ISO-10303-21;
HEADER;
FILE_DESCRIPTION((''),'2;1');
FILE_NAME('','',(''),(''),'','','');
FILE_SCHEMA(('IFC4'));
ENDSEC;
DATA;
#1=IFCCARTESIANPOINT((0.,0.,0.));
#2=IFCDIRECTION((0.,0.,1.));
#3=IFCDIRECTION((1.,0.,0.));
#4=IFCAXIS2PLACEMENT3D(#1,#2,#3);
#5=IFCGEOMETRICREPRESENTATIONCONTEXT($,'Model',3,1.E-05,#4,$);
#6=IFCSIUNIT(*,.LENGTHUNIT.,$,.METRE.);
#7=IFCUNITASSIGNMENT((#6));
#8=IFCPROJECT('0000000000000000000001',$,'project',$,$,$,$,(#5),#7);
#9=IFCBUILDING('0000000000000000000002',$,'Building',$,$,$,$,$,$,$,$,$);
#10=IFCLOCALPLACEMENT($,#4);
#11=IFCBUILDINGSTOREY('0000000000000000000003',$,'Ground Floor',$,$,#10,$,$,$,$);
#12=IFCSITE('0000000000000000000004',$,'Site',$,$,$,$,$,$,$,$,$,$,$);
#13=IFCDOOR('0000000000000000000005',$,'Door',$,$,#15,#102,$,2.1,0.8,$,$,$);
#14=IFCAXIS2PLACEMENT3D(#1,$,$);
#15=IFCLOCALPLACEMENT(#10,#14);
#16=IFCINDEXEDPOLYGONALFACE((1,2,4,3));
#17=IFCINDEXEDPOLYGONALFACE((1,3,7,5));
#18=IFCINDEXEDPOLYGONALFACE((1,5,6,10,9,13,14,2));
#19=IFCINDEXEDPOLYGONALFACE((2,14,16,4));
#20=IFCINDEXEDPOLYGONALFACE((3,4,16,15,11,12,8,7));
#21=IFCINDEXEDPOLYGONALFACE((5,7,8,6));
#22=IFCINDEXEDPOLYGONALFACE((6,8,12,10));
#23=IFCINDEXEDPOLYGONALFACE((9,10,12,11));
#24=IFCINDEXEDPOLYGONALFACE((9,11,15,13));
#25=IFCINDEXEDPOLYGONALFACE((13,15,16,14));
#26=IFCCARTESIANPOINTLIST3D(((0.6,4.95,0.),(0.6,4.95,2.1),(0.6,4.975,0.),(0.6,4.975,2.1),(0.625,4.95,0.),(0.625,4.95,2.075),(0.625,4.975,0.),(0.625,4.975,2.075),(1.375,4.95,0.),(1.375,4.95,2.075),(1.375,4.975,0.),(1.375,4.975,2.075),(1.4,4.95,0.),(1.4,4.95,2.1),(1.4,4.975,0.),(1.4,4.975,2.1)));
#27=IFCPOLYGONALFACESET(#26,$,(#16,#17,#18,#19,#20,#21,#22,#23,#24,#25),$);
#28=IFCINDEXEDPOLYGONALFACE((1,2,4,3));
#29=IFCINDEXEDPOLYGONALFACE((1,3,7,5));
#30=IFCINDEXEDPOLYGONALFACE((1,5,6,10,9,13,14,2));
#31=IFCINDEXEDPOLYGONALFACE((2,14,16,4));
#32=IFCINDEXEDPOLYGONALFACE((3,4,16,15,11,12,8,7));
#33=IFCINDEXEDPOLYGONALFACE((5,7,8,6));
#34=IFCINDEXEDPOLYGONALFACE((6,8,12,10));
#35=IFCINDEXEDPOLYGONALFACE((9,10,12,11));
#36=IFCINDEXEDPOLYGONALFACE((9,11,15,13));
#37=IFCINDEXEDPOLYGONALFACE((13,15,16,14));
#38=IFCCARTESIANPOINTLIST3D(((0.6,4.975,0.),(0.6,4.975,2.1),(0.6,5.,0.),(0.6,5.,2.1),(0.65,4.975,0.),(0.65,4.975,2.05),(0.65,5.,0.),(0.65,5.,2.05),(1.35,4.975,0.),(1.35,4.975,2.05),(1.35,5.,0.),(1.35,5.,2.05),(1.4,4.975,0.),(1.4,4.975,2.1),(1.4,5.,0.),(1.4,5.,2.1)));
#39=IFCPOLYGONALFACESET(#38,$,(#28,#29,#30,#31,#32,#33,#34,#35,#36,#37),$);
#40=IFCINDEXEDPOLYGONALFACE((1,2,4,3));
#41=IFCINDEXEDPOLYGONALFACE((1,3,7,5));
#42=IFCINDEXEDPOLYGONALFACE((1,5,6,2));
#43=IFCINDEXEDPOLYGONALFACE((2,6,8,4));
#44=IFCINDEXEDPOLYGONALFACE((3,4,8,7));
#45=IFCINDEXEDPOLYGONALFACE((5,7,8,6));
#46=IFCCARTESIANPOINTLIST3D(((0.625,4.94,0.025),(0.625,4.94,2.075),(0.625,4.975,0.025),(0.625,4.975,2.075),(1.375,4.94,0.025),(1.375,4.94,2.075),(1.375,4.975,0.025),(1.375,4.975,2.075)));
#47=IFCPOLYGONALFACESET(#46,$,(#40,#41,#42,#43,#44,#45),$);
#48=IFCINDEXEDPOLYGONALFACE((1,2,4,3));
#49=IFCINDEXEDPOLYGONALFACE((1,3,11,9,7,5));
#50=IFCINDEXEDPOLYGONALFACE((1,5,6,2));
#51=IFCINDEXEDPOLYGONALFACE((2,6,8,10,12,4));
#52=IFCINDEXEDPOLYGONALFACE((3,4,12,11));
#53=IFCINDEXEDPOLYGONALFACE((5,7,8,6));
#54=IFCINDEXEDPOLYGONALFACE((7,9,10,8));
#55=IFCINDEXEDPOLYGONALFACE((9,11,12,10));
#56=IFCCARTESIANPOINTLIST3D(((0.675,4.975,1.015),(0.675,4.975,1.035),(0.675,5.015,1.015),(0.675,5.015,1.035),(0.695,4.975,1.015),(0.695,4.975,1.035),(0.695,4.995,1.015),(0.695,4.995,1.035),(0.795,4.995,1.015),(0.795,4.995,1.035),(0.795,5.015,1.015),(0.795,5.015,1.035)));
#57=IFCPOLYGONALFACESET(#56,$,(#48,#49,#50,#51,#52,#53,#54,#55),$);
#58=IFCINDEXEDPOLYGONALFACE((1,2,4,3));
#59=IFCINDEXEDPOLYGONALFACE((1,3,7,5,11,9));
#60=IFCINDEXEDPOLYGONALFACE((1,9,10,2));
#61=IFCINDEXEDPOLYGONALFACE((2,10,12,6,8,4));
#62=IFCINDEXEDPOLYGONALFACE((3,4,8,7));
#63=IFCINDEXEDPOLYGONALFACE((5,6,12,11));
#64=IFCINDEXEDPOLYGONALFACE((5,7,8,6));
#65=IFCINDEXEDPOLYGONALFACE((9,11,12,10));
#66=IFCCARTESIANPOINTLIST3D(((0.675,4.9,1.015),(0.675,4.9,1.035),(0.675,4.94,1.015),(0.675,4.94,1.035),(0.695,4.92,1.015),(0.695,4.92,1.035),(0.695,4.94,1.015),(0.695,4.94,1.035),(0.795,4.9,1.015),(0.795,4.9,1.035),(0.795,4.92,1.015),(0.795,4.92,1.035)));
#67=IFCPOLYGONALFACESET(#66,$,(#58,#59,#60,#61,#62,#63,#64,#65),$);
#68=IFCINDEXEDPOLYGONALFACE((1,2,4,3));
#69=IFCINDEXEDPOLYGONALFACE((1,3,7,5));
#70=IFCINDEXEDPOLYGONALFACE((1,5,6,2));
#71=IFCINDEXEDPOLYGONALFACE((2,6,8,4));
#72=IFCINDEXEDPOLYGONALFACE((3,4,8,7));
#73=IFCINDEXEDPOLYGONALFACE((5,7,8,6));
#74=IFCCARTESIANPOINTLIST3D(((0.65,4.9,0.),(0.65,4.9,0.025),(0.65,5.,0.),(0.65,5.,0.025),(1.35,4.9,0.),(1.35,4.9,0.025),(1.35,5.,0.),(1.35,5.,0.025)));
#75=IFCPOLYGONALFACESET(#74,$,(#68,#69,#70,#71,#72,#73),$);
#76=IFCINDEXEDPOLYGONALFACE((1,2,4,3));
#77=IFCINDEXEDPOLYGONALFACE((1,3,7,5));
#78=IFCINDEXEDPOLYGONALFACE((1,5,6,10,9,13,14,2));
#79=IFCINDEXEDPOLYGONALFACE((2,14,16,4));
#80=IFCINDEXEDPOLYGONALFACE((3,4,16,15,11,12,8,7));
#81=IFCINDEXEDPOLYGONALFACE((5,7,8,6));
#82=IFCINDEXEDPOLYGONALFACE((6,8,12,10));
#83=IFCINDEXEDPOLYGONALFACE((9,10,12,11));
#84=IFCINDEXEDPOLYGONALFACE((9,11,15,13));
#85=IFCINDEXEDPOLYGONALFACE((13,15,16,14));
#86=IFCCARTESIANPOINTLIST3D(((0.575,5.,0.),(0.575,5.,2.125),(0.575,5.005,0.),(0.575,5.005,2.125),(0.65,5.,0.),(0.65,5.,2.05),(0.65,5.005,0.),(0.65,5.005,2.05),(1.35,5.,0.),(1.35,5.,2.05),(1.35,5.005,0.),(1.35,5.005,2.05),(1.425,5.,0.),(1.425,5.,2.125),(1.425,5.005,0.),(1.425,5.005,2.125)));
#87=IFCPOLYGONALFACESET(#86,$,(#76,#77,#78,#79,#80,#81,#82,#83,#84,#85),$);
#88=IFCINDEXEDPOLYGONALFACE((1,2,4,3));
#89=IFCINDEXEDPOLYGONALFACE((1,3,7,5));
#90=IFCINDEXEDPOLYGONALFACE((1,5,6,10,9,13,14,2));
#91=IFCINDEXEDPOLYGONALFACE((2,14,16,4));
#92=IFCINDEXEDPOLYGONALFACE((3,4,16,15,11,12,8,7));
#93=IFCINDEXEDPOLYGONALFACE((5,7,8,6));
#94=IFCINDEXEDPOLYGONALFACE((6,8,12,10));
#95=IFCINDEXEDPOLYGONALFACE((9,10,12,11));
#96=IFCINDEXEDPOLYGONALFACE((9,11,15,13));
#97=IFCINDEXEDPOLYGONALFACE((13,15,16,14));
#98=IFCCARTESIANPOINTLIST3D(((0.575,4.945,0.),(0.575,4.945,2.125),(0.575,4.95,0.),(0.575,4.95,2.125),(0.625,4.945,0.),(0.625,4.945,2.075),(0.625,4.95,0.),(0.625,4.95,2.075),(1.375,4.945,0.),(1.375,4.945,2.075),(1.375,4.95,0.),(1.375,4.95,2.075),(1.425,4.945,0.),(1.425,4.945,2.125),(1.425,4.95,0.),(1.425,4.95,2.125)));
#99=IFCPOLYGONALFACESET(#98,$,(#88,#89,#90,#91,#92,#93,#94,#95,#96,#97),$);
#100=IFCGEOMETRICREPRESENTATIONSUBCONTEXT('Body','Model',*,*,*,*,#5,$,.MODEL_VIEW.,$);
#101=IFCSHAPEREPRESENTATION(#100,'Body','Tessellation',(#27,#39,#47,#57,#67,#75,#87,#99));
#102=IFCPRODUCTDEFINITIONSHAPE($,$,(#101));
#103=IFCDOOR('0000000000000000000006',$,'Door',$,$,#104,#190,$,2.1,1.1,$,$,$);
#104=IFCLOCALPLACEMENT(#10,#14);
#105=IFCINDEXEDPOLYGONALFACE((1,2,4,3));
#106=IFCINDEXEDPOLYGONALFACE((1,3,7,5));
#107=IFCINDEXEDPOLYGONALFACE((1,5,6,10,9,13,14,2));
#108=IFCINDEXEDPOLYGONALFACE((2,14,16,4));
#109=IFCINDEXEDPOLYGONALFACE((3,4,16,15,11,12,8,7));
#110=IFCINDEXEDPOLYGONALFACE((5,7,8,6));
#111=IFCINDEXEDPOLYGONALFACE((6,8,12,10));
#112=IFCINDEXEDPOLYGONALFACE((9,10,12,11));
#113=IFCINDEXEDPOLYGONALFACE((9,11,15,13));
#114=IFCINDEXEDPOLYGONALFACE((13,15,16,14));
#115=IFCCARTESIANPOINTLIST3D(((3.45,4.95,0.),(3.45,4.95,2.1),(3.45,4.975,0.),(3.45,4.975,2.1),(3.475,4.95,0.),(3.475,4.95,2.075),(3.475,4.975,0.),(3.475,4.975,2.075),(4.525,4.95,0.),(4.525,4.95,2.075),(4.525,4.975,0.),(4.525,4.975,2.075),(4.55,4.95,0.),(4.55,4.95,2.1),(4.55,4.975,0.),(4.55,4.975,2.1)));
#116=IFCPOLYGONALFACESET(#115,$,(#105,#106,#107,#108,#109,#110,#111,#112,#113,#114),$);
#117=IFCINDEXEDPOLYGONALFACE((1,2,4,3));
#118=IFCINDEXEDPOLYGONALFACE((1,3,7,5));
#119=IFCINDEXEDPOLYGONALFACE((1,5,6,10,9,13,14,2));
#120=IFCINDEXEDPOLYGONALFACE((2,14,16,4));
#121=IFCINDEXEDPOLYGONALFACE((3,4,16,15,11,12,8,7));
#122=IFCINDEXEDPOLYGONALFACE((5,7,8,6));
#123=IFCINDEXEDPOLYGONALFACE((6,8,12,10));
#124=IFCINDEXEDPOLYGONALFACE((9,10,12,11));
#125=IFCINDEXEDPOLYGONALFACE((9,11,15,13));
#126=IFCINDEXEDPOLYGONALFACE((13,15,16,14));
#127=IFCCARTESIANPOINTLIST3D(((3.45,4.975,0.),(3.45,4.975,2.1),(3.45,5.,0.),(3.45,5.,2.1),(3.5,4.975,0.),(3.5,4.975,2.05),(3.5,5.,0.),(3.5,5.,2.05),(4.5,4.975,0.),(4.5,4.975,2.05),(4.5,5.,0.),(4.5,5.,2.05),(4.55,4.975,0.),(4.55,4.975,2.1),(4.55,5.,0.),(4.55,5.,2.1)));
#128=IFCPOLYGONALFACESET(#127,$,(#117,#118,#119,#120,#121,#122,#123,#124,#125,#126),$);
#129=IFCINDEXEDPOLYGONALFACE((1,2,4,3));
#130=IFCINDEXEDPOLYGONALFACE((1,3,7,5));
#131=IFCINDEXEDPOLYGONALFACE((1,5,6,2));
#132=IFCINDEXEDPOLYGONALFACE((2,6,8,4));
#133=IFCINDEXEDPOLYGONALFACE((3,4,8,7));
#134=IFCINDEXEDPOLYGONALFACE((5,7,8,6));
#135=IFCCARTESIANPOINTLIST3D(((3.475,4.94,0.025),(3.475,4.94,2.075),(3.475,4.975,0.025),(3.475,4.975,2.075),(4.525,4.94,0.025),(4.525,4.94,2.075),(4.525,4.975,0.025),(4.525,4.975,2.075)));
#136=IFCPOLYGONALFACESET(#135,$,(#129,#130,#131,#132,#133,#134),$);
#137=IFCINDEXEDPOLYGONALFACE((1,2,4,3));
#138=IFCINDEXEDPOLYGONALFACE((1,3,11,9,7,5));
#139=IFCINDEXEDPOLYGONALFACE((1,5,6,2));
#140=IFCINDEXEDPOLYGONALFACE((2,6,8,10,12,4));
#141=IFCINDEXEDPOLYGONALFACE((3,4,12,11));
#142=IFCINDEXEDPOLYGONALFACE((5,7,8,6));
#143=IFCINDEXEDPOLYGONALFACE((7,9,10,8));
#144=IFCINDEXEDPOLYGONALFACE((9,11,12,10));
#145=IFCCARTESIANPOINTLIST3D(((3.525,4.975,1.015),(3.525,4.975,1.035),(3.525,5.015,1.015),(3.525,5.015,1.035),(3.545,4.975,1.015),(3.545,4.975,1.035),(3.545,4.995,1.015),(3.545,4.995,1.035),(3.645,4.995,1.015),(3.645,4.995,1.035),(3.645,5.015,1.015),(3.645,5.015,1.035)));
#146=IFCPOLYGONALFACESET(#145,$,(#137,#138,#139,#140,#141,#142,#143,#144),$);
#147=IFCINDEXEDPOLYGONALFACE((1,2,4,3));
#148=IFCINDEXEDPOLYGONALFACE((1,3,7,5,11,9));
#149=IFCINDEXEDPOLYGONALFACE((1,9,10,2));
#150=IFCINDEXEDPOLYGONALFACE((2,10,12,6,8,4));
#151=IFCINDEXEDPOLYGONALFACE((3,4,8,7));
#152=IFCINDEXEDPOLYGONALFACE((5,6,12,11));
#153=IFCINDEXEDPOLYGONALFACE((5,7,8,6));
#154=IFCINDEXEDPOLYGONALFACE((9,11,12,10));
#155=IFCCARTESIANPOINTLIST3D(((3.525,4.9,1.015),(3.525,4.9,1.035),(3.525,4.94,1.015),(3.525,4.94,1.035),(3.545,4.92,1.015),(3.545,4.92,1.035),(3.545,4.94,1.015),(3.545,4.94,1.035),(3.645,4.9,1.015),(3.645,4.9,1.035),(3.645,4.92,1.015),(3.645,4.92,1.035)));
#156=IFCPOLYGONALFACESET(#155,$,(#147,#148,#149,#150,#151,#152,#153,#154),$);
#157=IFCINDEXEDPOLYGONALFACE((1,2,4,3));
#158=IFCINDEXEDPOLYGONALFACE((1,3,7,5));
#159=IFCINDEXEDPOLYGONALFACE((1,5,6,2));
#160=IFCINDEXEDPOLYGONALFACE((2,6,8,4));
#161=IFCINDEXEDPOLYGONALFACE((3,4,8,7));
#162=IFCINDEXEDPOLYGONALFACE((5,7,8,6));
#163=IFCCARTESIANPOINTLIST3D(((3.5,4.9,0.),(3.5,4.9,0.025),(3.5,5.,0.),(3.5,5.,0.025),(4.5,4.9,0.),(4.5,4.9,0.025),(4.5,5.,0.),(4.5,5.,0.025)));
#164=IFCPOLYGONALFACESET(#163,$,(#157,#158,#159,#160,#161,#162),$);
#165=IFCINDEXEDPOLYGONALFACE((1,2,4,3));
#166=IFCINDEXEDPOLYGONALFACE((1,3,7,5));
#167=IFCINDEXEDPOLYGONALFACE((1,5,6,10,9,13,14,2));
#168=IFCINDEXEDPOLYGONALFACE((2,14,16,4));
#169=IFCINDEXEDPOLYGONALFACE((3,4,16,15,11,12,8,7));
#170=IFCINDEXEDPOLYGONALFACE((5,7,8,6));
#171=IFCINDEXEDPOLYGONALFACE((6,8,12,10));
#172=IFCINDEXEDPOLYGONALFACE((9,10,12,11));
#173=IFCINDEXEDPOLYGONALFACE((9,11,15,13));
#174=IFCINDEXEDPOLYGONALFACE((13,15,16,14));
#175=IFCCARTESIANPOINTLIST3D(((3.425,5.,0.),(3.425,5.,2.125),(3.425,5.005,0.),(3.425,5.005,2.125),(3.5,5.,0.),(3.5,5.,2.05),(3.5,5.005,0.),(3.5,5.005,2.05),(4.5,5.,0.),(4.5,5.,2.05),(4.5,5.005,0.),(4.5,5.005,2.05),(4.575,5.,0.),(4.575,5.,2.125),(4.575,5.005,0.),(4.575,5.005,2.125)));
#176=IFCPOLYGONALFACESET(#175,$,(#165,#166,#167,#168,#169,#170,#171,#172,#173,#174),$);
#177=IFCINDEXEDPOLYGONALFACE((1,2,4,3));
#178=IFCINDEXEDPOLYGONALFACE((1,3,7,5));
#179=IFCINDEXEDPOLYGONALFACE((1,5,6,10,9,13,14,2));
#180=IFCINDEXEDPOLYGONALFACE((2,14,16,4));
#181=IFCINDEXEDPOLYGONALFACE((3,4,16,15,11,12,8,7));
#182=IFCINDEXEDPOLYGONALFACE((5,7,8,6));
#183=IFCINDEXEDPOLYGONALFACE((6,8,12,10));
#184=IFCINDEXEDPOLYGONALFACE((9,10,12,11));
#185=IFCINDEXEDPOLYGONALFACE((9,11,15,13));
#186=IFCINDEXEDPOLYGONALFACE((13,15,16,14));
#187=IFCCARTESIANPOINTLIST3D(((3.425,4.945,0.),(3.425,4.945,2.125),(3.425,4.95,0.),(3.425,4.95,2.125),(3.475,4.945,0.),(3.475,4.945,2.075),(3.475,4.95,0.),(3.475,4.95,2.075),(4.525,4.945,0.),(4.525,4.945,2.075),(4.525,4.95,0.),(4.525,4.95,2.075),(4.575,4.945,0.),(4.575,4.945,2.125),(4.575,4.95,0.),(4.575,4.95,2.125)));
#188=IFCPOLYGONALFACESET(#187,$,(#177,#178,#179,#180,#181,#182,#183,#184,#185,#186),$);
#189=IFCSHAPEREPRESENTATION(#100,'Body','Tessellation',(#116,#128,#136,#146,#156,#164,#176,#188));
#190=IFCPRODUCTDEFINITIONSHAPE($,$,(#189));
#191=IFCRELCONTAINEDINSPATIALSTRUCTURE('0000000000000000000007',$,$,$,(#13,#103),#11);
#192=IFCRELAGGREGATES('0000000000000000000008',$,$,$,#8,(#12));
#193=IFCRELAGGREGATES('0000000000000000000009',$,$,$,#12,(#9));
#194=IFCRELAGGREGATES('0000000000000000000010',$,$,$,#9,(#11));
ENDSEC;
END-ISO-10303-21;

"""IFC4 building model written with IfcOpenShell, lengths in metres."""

from ifc_helpers import new_model, si_unit, frame, origin_with_axes, place, context, subcontext, project, spatial, line, indexed_curve, outline, extrude, element, save


model = new_model("IFC4")

# Units and contexts
model_context = context("Model", 3, precision=1e-05, world=origin_with_axes())
body_context = subcontext(model_context, "Body", "Model", "MODEL_VIEW")
ifc_project = project(units=[si_unit("LENGTHUNIT", "METRE")], contexts=[model_context])

# Site, building, storey
site = spatial("IfcSite", under=ifc_project, Name="Site")
building = spatial("IfcBuilding", under=site, Name="Building")
storey_placement = place(None, origin_with_axes())
storey = spatial("IfcBuildingStorey", under=building, at=storey_placement, Name="Ground Floor")

# Doors
door_1_placement = place(storey_placement, frame((1.4, 5.0, 0.0), z_axis=(0.0, 0.0, 1.0), x_axis=(-1.0, 0.0, 0.0)))
element("IfcDoor", 1, at=door_1_placement, inside=storey, Name="Door", OverallHeight=2.1, OverallWidth=0.8, context=body_context, shape_type="SweptSolid", body=[
    extrude(outline(indexed_curve([(0.0, 0.0), (0.0, 2.1), (0.8, 2.1), (0.8, 0.0), (0.775, 0.0), (0.775, 2.075), (0.025, 2.075), (0.025, 0.0)], segments=[line(1, 2, 3, 4, 5, 6, 7, 8, 1)])), frame((0.0, 0.025, 0.0), z_axis=(0.0, -1.0, 0.0), x_axis=(1.0, 0.0, 0.0)), (0.0, 0.0, -1.0), 0.025),
    extrude(outline(indexed_curve([(0.0, 0.0), (0.0, 2.1), (0.8, 2.1), (0.8, 0.0), (0.75, 0.0), (0.75, 2.05), (0.05, 2.05), (0.05, 0.0)], segments=[line(1, 2, 3, 4, 5, 6, 7, 8, 1)])), frame((0.0, 0.0, 0.0), z_axis=(0.0, -1.0, 0.0), x_axis=(1.0, 0.0, 0.0)), (0.0, 0.0, -1.0), 0.025),
    extrude(outline(indexed_curve([(0.0, 0.0), (0.75, 0.0), (0.75, 0.035), (0.0, 0.035)], segments=[line(1, 2, 3, 4, 1)])), frame((0.025, 0.025, 0.025), z_axis=(0.0, 0.0, 1.0), x_axis=(1.0, 0.0, 0.0)), (0.0, 0.0, 1.0), 2.05),
    extrude(outline(indexed_curve([(0.0, 0.0), (0.0, -0.04), (-0.12, -0.04), (-0.12, -0.02), (-0.02, -0.02), (-0.02, 0.0)], segments=[line(1, 2, 3, 4, 5, 6, 1)])), frame((0.725, 0.025, 1.015), z_axis=(0.0, 0.0, 1.0), x_axis=(1.0, 0.0, 0.0)), (0.0, 0.0, 1.0), 0.02),
    extrude(outline(indexed_curve([(0.0, 0.0), (0.0, 0.04), (-0.12, 0.04), (-0.12, 0.02), (-0.02, 0.02), (-0.02, 0.0)], segments=[line(1, 2, 3, 4, 5, 6, 1)])), frame((0.725, 0.06, 1.015), z_axis=(0.0, 0.0, 1.0), x_axis=(1.0, 0.0, 0.0)), (0.0, 0.0, 1.0), 0.02),
    extrude(outline(indexed_curve([(0.0, 0.0), (0.7, 0.0), (0.7, 0.1), (0.0, 0.1)], segments=[line(1, 2, 3, 4, 1)])), frame((0.05, 0.0, 0.0), z_axis=(0.0, 0.0, 1.0), x_axis=(1.0, 0.0, 0.0)), (0.0, 0.0, 1.0), 0.025),
    extrude(outline(indexed_curve([(0.0, 0.0), (0.0, 2.125), (0.85, 2.125), (0.85, 0.0), (0.775, 0.0), (0.775, 2.05), (0.075, 2.05), (0.075, 0.0)], segments=[line(1, 2, 3, 4, 5, 6, 7, 8, 1)])), frame((-0.025, -0.005, 0.0), z_axis=(0.0, -1.0, 0.0), x_axis=(1.0, 0.0, 0.0)), (0.0, 0.0, -1.0), 0.005),
    extrude(outline(indexed_curve([(0.0, 0.0), (0.0, 2.125), (0.85, 2.125), (0.85, 0.0), (0.8, 0.0), (0.8, 2.075), (0.05, 2.075), (0.05, 0.0)], segments=[line(1, 2, 3, 4, 5, 6, 7, 8, 1)])), frame((-0.025, 0.05, 0.0), z_axis=(0.0, -1.0, 0.0), x_axis=(1.0, 0.0, 0.0)), (0.0, 0.0, -1.0), 0.005),
])
door_2_placement = place(storey_placement, frame((4.55, 5.0, 0.0), z_axis=(0.0, 0.0, 1.0), x_axis=(-1.0, 0.0, 0.0)))
element("IfcDoor", 2, at=door_2_placement, inside=storey, Name="Door", OverallHeight=2.1, OverallWidth=1.1, context=body_context, shape_type="SweptSolid", body=[
    extrude(outline(indexed_curve([(0.0, 0.0), (0.0, 2.1), (1.1, 2.1), (1.1, 0.0), (1.075, 0.0), (1.075, 2.075), (0.025, 2.075), (0.025, 0.0)], segments=[line(1, 2, 3, 4, 5, 6, 7, 8, 1)])), frame((0.0, 0.025, 0.0), z_axis=(0.0, -1.0, 0.0), x_axis=(1.0, 0.0, 0.0)), (0.0, 0.0, -1.0), 0.025),
    extrude(outline(indexed_curve([(0.0, 0.0), (0.0, 2.1), (1.1, 2.1), (1.1, 0.0), (1.05, 0.0), (1.05, 2.05), (0.05, 2.05), (0.05, 0.0)], segments=[line(1, 2, 3, 4, 5, 6, 7, 8, 1)])), frame((0.0, 0.0, 0.0), z_axis=(0.0, -1.0, 0.0), x_axis=(1.0, 0.0, 0.0)), (0.0, 0.0, -1.0), 0.025),
    extrude(outline(indexed_curve([(0.0, 0.0), (1.05, 0.0), (1.05, 0.035), (0.0, 0.035)], segments=[line(1, 2, 3, 4, 1)])), frame((0.025, 0.025, 0.025), z_axis=(0.0, 0.0, 1.0), x_axis=(1.0, 0.0, 0.0)), (0.0, 0.0, 1.0), 2.05),
    extrude(outline(indexed_curve([(0.0, 0.0), (0.0, -0.04), (-0.12, -0.04), (-0.12, -0.02), (-0.02, -0.02), (-0.02, 0.0)], segments=[line(1, 2, 3, 4, 5, 6, 1)])), frame((1.025, 0.025, 1.015), z_axis=(0.0, 0.0, 1.0), x_axis=(1.0, 0.0, 0.0)), (0.0, 0.0, 1.0), 0.02),
    extrude(outline(indexed_curve([(0.0, 0.0), (0.0, 0.04), (-0.12, 0.04), (-0.12, 0.02), (-0.02, 0.02), (-0.02, 0.0)], segments=[line(1, 2, 3, 4, 5, 6, 1)])), frame((1.025, 0.06, 1.015), z_axis=(0.0, 0.0, 1.0), x_axis=(1.0, 0.0, 0.0)), (0.0, 0.0, 1.0), 0.02),
    extrude(outline(indexed_curve([(0.0, 0.0), (1.0, 0.0), (1.0, 0.1), (0.0, 0.1)], segments=[line(1, 2, 3, 4, 1)])), frame((0.05, 0.0, 0.0), z_axis=(0.0, 0.0, 1.0), x_axis=(1.0, 0.0, 0.0)), (0.0, 0.0, 1.0), 0.025),
    extrude(outline(indexed_curve([(0.0, 0.0), (0.0, 2.125), (1.15, 2.125), (1.15, 0.0), (1.075, 0.0), (1.075, 2.05), (0.075, 2.05), (0.075, 0.0)], segments=[line(1, 2, 3, 4, 5, 6, 7, 8, 1)])), frame((-0.025, -0.005, 0.0), z_axis=(0.0, -1.0, 0.0), x_axis=(1.0, 0.0, 0.0)), (0.0, 0.0, -1.0), 0.005),
    extrude(outline(indexed_curve([(0.0, 0.0), (0.0, 2.125), (1.15, 2.125), (1.15, 0.0), (1.1, 0.0), (1.1, 2.075), (0.05, 2.075), (0.05, 0.0)], segments=[line(1, 2, 3, 4, 5, 6, 7, 8, 1)])), frame((-0.025, 0.05, 0.0), z_axis=(0.0, -1.0, 0.0), x_axis=(1.0, 0.0, 0.0)), (0.0, 0.0, -1.0), 0.005),
])

save(model, "model.ifc")
